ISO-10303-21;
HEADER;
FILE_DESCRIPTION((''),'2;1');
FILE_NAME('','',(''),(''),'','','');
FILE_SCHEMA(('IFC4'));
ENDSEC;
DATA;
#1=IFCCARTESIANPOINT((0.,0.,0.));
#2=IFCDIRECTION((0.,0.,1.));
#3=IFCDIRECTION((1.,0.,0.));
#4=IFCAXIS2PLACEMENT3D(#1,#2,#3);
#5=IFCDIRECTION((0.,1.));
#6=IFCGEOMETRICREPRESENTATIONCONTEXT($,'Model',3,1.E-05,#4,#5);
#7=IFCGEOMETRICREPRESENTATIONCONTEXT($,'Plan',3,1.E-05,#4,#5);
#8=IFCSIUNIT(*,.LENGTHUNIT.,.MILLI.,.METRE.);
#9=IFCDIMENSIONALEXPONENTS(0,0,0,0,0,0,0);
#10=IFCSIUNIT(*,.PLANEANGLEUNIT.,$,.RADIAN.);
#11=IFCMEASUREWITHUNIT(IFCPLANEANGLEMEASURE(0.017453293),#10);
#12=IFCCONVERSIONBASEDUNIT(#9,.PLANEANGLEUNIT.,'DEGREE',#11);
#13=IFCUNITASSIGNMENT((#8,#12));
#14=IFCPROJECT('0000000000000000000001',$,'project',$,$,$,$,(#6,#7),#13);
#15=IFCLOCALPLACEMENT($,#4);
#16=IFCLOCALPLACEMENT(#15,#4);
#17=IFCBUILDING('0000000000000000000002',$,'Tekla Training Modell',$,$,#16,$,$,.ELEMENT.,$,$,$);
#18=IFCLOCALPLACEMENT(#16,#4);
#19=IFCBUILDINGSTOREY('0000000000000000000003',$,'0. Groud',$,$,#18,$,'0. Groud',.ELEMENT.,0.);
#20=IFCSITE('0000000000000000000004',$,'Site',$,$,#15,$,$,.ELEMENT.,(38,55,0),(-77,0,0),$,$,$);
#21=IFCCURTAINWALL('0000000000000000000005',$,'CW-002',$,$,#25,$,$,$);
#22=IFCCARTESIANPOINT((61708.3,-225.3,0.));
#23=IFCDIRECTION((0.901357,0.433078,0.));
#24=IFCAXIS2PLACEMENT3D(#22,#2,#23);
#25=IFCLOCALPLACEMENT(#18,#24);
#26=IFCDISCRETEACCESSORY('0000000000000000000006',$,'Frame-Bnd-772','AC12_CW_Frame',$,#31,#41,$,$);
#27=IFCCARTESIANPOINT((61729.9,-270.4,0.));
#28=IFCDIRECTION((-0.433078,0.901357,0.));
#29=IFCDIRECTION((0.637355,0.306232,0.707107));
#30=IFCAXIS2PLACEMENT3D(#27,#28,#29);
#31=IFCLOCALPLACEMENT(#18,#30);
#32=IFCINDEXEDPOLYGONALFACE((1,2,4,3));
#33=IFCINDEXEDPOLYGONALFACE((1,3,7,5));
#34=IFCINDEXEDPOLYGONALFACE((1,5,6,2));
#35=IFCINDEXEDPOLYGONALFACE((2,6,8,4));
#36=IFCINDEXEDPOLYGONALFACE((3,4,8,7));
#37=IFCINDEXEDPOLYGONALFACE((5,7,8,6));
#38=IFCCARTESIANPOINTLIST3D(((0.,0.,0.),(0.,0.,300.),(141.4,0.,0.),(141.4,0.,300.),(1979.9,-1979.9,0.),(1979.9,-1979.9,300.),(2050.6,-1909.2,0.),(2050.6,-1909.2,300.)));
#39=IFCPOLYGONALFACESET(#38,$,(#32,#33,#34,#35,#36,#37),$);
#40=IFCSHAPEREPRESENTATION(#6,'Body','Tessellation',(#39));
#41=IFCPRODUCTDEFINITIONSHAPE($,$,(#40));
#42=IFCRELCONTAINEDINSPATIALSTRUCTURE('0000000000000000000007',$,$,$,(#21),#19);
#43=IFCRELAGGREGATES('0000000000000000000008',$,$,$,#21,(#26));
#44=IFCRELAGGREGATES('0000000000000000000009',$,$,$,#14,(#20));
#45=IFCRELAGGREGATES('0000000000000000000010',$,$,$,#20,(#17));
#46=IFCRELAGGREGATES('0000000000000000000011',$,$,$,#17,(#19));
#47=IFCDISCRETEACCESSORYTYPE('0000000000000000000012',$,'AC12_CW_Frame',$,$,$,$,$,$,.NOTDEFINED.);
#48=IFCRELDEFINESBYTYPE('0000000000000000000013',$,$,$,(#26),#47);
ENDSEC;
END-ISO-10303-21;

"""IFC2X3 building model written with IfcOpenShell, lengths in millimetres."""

from ifc_helpers import new_model, entity, si_unit, converted_unit, direction, frame, origin_with_axes, place, context, project, spatial, polyline, outline, extrude, source, transform, mapped, type_object, element, aggregate, save


model = new_model("IFC2X3")

# Units and contexts
model_context = context("Model", 3, precision=1e-05, world=origin_with_axes(), true_north=direction((0.0, 1.0)))
plan_context = context("Plan", 3, precision=1e-05, world=origin_with_axes(), true_north=direction((0.0, 1.0)))
ifc_project = project(units=[si_unit("LENGTHUNIT", "METRE", prefix="MILLI"), converted_unit("PLANEANGLEUNIT", "DEGREE", entity("IfcPlaneAngleMeasure", 0.017453293), si_unit("PLANEANGLEUNIT", "RADIAN"), dimensions=[0, 0, 0, 0, 0, 0, 0])], contexts=[model_context, plan_context])

# Site, building, storey
site_placement = place(None, origin_with_axes())
site = spatial("IfcSite", under=ifc_project, at=site_placement, Name="Site", CompositionType="ELEMENT", RefLatitude=(38, 55, 0), RefLongitude=(-77, 0, 0))
building_placement = place(site_placement, origin_with_axes())
building = spatial("IfcBuilding", under=site, at=building_placement, Name="Tekla Training Modell", CompositionType="ELEMENT")
storey_placement = place(building_placement, origin_with_axes())
storey = spatial("IfcBuildingStorey", under=building, at=storey_placement, Name="0. Groud", LongName="0. Groud", CompositionType="ELEMENT", Elevation=0.0)

# Curtain wall
curtain_wall_1_placement = place(storey_placement, frame((61708.3, -225.3, 0.0), z_axis=(0.0, 0.0, 1.0), x_axis=(0.901357, 0.433078, 0.0)))
curtain_wall_1 = element("IfcCurtainWall", 1, at=curtain_wall_1_placement, inside=storey, Name="CW-002")

# Discrete accessory
discrete_accessory_type = type_object("IfcDiscreteAccessoryType", Name="AC12_CW_Frame")
shared_shape_1 = source(origin_with_axes(), model_context, "Body", "SweptSolid", [
    extrude(outline(polyline([(0.0, 0.0), (141.4, 0.0), (2050.6, -1909.2), (1979.9, -1979.9), (0.0, 0.0)])), origin_with_axes(), (0.0, 0.0, 1.0), 300.0),
])
discrete_accessory_1_placement = place(storey_placement, frame((61729.9, -270.4, 0.0), z_axis=(-0.433078, 0.901357, 0.0), x_axis=(0.637355, 0.306232, 0.707107)))
discrete_accessory_1 = element("IfcDiscreteAccessory", 2, at=discrete_accessory_1_placement, type_object=discrete_accessory_type, Name="Frame-Bnd-772", Description="AC12_CW_Frame", context=model_context, shape_type="MappedRepresentation", body=[
    mapped(shared_shape_1, transform((0.0, 0.0, 0.0), scale=1.0)),
])
aggregate(curtain_wall_1, [discrete_accessory_1])

save(model, "model.ifc")
